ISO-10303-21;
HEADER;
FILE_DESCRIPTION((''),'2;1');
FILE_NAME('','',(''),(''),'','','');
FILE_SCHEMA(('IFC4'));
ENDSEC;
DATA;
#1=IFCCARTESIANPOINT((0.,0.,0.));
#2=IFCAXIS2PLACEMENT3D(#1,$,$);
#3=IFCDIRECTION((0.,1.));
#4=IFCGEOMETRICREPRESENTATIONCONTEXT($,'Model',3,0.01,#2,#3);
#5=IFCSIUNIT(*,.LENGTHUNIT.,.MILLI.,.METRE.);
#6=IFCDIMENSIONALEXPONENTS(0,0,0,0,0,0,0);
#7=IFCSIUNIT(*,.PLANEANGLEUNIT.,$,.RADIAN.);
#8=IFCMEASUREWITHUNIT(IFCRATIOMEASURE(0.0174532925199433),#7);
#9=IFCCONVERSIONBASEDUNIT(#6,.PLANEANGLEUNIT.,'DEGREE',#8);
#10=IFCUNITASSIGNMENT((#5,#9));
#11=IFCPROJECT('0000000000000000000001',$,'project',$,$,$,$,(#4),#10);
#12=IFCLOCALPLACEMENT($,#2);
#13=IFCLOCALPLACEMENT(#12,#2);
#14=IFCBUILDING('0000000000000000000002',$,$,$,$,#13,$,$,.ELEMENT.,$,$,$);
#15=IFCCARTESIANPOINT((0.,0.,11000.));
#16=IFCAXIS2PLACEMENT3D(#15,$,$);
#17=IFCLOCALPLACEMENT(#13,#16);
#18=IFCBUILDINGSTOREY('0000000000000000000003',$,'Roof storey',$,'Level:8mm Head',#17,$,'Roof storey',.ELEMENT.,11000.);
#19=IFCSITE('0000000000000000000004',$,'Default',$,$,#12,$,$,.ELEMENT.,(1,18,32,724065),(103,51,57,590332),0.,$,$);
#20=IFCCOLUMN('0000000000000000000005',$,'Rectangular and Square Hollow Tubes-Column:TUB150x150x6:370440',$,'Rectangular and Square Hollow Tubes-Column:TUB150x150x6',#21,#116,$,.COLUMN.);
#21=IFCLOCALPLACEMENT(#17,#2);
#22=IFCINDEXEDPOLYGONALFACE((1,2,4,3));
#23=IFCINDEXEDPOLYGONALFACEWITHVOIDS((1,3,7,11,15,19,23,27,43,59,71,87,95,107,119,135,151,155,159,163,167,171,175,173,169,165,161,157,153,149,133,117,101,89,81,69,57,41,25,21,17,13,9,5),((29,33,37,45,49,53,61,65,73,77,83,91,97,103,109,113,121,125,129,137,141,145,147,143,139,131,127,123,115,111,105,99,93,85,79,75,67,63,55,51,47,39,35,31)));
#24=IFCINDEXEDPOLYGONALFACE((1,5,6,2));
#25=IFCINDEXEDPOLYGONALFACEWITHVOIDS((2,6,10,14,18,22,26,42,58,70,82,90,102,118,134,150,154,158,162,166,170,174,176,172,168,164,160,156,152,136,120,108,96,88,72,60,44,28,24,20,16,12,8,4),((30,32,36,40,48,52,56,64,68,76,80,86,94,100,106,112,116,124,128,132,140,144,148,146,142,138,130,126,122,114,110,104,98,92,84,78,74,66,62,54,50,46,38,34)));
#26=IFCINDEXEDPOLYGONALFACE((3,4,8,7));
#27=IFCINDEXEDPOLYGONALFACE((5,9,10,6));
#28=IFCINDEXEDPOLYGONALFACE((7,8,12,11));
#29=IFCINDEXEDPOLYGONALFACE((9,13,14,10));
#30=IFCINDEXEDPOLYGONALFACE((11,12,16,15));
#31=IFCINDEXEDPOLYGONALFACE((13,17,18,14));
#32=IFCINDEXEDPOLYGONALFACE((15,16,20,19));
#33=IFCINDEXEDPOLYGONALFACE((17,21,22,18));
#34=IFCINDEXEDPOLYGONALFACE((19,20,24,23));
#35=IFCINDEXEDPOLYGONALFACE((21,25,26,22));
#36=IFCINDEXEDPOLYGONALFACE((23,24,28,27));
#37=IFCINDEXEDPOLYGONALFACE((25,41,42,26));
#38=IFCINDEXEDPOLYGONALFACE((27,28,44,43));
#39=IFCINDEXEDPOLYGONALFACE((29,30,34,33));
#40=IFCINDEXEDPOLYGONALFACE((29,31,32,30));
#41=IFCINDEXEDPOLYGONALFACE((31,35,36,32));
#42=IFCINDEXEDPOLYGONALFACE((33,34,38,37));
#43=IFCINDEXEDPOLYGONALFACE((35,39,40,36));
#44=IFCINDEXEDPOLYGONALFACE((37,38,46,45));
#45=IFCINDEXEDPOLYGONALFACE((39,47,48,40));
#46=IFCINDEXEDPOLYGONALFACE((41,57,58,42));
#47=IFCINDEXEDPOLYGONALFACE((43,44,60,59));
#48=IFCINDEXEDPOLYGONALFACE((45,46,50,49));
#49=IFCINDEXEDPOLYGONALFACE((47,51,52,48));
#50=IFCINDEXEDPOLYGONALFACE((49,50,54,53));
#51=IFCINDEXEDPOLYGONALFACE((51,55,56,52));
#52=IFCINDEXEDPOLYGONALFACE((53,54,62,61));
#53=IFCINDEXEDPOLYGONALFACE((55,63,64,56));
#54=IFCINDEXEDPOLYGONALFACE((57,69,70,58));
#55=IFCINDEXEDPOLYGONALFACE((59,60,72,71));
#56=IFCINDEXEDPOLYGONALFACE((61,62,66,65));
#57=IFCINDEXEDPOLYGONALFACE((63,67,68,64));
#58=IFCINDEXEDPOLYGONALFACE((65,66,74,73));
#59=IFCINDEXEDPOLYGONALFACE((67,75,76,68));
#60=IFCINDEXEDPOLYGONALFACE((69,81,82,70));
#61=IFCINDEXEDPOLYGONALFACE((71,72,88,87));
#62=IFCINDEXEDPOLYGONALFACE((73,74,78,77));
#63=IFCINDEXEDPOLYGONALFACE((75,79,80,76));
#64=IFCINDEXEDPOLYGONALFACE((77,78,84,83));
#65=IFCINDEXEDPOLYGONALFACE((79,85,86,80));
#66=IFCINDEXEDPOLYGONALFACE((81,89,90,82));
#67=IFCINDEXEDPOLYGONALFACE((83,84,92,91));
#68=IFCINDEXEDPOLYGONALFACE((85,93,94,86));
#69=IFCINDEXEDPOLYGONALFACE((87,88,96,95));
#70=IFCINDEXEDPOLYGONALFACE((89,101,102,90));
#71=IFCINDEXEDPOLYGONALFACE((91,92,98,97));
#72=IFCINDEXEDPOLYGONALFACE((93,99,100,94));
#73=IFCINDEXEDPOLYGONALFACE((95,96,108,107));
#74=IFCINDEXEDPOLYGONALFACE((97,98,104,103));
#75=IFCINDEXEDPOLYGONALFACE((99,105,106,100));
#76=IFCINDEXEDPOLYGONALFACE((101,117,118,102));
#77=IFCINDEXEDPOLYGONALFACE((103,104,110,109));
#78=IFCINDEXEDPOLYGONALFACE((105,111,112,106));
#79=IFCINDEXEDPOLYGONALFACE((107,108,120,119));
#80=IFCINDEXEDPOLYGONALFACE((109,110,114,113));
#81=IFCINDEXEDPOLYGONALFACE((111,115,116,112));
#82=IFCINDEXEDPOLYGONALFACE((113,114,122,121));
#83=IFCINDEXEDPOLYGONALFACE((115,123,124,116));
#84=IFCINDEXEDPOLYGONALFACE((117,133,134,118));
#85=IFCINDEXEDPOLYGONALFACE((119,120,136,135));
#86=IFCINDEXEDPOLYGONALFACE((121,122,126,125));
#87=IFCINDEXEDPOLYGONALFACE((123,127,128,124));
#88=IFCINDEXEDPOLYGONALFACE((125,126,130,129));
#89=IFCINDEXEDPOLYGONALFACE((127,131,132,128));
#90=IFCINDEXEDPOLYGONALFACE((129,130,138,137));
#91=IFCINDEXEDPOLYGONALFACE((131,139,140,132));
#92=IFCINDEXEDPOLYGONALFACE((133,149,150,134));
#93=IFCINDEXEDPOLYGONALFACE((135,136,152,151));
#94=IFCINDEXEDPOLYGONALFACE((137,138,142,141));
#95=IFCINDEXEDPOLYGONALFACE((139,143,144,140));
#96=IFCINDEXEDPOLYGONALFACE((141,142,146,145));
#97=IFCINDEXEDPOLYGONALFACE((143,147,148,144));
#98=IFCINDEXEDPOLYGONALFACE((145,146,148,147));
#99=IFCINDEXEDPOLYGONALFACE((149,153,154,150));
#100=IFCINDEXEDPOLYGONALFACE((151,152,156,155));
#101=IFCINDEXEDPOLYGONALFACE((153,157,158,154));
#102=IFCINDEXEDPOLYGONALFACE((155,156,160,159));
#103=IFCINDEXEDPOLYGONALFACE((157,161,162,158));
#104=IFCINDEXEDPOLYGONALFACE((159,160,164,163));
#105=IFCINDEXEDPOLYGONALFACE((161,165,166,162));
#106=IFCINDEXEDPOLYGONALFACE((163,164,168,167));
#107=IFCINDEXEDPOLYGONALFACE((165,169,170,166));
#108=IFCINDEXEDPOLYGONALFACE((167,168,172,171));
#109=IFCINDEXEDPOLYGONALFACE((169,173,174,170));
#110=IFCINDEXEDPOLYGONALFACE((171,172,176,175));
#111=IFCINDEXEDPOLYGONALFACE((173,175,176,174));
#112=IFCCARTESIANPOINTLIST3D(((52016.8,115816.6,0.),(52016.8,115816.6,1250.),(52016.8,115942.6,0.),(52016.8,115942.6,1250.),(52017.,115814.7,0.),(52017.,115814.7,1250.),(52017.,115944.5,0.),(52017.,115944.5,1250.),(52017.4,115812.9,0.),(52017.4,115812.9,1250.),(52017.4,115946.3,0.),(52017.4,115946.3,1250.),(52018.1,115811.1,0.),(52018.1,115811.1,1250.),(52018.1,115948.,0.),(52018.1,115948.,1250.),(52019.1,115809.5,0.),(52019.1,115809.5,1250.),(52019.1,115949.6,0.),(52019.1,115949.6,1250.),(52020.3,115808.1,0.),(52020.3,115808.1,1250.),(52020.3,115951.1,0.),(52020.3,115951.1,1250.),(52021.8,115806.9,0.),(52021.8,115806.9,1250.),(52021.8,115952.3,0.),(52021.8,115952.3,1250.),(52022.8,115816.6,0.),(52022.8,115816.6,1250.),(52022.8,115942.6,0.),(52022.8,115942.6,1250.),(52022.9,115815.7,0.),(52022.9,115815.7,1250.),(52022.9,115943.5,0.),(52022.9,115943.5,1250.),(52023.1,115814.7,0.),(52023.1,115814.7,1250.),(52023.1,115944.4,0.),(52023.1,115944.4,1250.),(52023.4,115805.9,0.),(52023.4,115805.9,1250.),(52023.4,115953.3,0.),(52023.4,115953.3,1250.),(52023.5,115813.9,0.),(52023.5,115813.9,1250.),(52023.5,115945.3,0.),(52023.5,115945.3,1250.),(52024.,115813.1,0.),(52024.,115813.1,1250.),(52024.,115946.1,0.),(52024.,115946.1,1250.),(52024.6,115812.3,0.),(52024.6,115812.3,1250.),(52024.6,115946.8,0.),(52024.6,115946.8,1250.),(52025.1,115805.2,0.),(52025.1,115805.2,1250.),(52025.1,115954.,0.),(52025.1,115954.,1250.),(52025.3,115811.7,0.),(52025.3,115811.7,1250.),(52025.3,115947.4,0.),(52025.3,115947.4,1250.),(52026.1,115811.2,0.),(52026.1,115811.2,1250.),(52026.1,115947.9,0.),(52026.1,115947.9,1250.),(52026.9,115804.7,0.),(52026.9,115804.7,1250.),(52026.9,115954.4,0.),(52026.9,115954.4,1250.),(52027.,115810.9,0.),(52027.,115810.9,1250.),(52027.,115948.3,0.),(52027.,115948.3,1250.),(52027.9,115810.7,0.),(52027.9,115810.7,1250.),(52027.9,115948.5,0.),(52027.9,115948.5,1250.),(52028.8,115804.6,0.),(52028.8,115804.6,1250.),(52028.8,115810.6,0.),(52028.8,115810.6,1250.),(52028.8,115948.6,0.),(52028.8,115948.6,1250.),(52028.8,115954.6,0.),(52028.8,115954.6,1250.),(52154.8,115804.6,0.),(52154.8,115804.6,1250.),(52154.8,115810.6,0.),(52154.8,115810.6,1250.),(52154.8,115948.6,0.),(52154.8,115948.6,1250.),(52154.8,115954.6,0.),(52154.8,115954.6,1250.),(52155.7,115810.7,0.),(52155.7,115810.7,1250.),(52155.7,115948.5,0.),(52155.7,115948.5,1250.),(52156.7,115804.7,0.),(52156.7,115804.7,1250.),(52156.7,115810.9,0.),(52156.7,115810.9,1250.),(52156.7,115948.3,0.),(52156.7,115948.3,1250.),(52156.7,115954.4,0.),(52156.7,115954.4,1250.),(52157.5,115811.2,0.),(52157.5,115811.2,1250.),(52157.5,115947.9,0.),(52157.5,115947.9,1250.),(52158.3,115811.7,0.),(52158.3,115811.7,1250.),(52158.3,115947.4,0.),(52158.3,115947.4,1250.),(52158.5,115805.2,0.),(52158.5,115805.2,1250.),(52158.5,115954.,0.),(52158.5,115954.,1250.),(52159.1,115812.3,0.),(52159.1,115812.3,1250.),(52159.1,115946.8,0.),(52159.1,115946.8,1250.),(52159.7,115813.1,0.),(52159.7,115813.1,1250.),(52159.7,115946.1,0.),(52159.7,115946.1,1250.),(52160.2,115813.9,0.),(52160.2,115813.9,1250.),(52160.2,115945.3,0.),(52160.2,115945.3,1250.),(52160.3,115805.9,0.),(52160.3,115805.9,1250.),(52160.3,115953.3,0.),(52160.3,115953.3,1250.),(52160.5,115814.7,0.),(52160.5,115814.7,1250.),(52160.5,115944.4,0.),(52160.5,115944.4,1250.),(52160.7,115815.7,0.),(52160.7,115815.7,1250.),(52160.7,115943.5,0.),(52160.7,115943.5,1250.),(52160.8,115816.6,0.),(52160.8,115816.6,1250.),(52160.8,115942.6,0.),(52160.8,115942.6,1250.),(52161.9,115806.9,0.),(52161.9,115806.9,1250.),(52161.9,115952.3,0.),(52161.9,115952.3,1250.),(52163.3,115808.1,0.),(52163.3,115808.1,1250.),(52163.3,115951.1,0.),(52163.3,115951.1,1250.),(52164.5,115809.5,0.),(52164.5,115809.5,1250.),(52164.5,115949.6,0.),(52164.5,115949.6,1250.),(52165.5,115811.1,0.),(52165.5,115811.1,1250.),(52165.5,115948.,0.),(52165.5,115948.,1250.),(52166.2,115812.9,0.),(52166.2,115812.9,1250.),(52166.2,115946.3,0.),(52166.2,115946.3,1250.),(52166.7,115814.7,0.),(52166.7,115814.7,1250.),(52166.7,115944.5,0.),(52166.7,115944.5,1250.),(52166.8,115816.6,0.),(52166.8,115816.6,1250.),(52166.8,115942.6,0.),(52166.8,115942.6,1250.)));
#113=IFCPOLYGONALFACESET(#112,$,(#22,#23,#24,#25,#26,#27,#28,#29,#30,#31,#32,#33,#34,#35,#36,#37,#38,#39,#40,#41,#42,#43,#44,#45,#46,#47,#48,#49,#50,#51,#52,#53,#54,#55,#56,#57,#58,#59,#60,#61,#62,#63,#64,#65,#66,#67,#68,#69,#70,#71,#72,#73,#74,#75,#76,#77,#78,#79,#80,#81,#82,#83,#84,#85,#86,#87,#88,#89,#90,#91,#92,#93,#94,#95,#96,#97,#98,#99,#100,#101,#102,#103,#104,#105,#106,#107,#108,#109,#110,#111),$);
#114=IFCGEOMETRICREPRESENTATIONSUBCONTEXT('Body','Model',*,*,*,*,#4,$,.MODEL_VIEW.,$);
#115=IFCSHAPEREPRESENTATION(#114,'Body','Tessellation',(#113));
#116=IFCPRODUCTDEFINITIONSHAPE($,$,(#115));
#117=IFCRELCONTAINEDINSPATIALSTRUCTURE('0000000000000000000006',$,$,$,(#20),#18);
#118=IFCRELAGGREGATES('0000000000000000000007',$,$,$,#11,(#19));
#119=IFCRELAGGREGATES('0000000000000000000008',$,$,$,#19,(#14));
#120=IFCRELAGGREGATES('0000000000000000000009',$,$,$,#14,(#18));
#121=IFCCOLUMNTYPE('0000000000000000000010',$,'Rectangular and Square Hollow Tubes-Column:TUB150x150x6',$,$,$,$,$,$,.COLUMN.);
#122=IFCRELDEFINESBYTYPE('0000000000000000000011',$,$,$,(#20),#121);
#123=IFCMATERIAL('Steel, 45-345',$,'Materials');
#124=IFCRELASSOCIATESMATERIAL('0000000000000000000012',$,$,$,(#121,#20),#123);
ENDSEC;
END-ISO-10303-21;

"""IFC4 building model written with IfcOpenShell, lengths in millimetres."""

from ifc_helpers import new_model, entity, si_unit, converted_unit, direction, frame, origin, place, context, subcontext, project, spatial, indexed_curve, outline, extrude, source, transform, mapped, material, type_object, type_shapes, element, save


model = new_model("IFC4")

# Units and contexts
model_context = context("Model", 3, precision=0.01, world=origin(), true_north=direction((0.0, 1.0)))
body_context = subcontext(model_context, "Body", "Model", "MODEL_VIEW")
ifc_project = project(units=[si_unit("LENGTHUNIT", "METRE", prefix="MILLI"), converted_unit("PLANEANGLEUNIT", "DEGREE", entity("IfcRatioMeasure", 0.0174532925199433), si_unit("PLANEANGLEUNIT", "RADIAN"), dimensions=[0, 0, 0, 0, 0, 0, 0])], contexts=[model_context])

# Site, building, storey
site_placement = place(None, origin())
site = spatial("IfcSite", under=ifc_project, at=site_placement, Name="Default", CompositionType="ELEMENT", RefLatitude=(1, 18, 32, 724065), RefLongitude=(103, 51, 57, 590332), RefElevation=0.0)
building_placement = place(site_placement, origin())
building = spatial("IfcBuilding", under=site, at=building_placement, CompositionType="ELEMENT")
storey_placement = place(building_placement, frame((0.0, 0.0, 11000.0)))
storey = spatial("IfcBuildingStorey", under=building, at=storey_placement, Name="Roof storey", ObjectType="Level:8mm Head", LongName="Roof storey", CompositionType="ELEMENT", Elevation=11000.0)

# Column
ifc_material = material(Name="Steel, 45-345", Category="Materials")
column_type = type_object("IfcColumnType", Name="Rectangular and Square Hollow Tubes-Column:TUB150x150x6", PredefinedType="COLUMN", material=ifc_material)
shared_shape_1 = source(origin(), body_context, "Body", "SweptSolid", [
    extrude(outline(indexed_curve([(-63.0, -75.0), (63.0, -75.0), (64.9, -74.9), (66.7, -74.4), (68.4, -73.7), (70.1, -72.7), (71.5, -71.5), (72.7, -70.1), (73.7, -68.4), (74.4, -66.7), (74.9, -64.9), (75.0, -63.0), (75.0, 63.0), (74.9, 64.9), (74.4, 66.7), (73.7, 68.4), (72.7, 70.1), (71.5, 71.5), (70.1, 72.7), (68.4, 73.7), (66.7, 74.4), (64.9, 74.9), (63.0, 75.0), (-63.0, 75.0), (-64.9, 74.9), (-66.7, 74.4), (-68.4, 73.7), (-70.1, 72.7), (-71.5, 71.5), (-72.7, 70.1), (-73.7, 68.4), (-74.4, 66.7), (-74.9, 64.9), (-75.0, 63.0), (-75.0, -63.0), (-74.9, -64.9), (-74.4, -66.7), (-73.7, -68.4), (-72.7, -70.1), (-71.5, -71.5), (-70.1, -72.7), (-68.4, -73.7), (-66.7, -74.4), (-64.9, -74.9), (-63.0, -75.0)], self_intersect=False), holes=[indexed_curve([(-63.0, -69.0), (-63.9, -68.9), (-64.9, -68.7), (-65.7, -68.3), (-66.5, -67.9), (-67.2, -67.2), (-67.9, -66.5), (-68.3, -65.7), (-68.7, -64.9), (-68.9, -63.9), (-69.0, -63.0), (-69.0, 63.0), (-68.9, 63.9), (-68.7, 64.9), (-68.3, 65.7), (-67.9, 66.5), (-67.2, 67.2), (-66.5, 67.9), (-65.7, 68.3), (-64.9, 68.7), (-63.9, 68.9), (-63.0, 69.0), (63.0, 69.0), (63.9, 68.9), (64.9, 68.7), (65.7, 68.3), (66.5, 67.9), (67.2, 67.2), (67.9, 66.5), (68.3, 65.7), (68.7, 64.9), (68.9, 63.9), (69.0, 63.0), (69.0, -63.0), (68.9, -63.9), (68.7, -64.9), (68.3, -65.7), (67.9, -66.5), (67.2, -67.2), (66.5, -67.9), (65.7, -68.3), (64.9, -68.7), (63.9, -68.9), (63.0, -69.0), (-63.0, -69.0)], self_intersect=False)]), frame((0.0, 0.0, 11000.0), z_axis=(0.0, 0.0, 1.0), x_axis=(-1.0, 0.0, 0.0)), (0.0, 0.0, 1.0), 1250.0),
])
type_shapes(column_type, [shared_shape_1])
for number, where, name in (
    (1, (52091.8, 115879.6, -11000.0), "Rectangular and Square Hollow Tubes-Column:TUB150x150x6:370440"),
):
    element("IfcColumn", number, at=place(storey_placement, frame(where)), inside=storey, type_object=column_type, material=ifc_material, Name=name, ObjectType="Rectangular and Square Hollow Tubes-Column:TUB150x150x6", PredefinedType="COLUMN", context=body_context, shape_type="MappedRepresentation", body=[
        mapped(shared_shape_1, transform((0.0, 0.0, 0.0), scale=1.0)),
    ])

save(model, "model.ifc")
